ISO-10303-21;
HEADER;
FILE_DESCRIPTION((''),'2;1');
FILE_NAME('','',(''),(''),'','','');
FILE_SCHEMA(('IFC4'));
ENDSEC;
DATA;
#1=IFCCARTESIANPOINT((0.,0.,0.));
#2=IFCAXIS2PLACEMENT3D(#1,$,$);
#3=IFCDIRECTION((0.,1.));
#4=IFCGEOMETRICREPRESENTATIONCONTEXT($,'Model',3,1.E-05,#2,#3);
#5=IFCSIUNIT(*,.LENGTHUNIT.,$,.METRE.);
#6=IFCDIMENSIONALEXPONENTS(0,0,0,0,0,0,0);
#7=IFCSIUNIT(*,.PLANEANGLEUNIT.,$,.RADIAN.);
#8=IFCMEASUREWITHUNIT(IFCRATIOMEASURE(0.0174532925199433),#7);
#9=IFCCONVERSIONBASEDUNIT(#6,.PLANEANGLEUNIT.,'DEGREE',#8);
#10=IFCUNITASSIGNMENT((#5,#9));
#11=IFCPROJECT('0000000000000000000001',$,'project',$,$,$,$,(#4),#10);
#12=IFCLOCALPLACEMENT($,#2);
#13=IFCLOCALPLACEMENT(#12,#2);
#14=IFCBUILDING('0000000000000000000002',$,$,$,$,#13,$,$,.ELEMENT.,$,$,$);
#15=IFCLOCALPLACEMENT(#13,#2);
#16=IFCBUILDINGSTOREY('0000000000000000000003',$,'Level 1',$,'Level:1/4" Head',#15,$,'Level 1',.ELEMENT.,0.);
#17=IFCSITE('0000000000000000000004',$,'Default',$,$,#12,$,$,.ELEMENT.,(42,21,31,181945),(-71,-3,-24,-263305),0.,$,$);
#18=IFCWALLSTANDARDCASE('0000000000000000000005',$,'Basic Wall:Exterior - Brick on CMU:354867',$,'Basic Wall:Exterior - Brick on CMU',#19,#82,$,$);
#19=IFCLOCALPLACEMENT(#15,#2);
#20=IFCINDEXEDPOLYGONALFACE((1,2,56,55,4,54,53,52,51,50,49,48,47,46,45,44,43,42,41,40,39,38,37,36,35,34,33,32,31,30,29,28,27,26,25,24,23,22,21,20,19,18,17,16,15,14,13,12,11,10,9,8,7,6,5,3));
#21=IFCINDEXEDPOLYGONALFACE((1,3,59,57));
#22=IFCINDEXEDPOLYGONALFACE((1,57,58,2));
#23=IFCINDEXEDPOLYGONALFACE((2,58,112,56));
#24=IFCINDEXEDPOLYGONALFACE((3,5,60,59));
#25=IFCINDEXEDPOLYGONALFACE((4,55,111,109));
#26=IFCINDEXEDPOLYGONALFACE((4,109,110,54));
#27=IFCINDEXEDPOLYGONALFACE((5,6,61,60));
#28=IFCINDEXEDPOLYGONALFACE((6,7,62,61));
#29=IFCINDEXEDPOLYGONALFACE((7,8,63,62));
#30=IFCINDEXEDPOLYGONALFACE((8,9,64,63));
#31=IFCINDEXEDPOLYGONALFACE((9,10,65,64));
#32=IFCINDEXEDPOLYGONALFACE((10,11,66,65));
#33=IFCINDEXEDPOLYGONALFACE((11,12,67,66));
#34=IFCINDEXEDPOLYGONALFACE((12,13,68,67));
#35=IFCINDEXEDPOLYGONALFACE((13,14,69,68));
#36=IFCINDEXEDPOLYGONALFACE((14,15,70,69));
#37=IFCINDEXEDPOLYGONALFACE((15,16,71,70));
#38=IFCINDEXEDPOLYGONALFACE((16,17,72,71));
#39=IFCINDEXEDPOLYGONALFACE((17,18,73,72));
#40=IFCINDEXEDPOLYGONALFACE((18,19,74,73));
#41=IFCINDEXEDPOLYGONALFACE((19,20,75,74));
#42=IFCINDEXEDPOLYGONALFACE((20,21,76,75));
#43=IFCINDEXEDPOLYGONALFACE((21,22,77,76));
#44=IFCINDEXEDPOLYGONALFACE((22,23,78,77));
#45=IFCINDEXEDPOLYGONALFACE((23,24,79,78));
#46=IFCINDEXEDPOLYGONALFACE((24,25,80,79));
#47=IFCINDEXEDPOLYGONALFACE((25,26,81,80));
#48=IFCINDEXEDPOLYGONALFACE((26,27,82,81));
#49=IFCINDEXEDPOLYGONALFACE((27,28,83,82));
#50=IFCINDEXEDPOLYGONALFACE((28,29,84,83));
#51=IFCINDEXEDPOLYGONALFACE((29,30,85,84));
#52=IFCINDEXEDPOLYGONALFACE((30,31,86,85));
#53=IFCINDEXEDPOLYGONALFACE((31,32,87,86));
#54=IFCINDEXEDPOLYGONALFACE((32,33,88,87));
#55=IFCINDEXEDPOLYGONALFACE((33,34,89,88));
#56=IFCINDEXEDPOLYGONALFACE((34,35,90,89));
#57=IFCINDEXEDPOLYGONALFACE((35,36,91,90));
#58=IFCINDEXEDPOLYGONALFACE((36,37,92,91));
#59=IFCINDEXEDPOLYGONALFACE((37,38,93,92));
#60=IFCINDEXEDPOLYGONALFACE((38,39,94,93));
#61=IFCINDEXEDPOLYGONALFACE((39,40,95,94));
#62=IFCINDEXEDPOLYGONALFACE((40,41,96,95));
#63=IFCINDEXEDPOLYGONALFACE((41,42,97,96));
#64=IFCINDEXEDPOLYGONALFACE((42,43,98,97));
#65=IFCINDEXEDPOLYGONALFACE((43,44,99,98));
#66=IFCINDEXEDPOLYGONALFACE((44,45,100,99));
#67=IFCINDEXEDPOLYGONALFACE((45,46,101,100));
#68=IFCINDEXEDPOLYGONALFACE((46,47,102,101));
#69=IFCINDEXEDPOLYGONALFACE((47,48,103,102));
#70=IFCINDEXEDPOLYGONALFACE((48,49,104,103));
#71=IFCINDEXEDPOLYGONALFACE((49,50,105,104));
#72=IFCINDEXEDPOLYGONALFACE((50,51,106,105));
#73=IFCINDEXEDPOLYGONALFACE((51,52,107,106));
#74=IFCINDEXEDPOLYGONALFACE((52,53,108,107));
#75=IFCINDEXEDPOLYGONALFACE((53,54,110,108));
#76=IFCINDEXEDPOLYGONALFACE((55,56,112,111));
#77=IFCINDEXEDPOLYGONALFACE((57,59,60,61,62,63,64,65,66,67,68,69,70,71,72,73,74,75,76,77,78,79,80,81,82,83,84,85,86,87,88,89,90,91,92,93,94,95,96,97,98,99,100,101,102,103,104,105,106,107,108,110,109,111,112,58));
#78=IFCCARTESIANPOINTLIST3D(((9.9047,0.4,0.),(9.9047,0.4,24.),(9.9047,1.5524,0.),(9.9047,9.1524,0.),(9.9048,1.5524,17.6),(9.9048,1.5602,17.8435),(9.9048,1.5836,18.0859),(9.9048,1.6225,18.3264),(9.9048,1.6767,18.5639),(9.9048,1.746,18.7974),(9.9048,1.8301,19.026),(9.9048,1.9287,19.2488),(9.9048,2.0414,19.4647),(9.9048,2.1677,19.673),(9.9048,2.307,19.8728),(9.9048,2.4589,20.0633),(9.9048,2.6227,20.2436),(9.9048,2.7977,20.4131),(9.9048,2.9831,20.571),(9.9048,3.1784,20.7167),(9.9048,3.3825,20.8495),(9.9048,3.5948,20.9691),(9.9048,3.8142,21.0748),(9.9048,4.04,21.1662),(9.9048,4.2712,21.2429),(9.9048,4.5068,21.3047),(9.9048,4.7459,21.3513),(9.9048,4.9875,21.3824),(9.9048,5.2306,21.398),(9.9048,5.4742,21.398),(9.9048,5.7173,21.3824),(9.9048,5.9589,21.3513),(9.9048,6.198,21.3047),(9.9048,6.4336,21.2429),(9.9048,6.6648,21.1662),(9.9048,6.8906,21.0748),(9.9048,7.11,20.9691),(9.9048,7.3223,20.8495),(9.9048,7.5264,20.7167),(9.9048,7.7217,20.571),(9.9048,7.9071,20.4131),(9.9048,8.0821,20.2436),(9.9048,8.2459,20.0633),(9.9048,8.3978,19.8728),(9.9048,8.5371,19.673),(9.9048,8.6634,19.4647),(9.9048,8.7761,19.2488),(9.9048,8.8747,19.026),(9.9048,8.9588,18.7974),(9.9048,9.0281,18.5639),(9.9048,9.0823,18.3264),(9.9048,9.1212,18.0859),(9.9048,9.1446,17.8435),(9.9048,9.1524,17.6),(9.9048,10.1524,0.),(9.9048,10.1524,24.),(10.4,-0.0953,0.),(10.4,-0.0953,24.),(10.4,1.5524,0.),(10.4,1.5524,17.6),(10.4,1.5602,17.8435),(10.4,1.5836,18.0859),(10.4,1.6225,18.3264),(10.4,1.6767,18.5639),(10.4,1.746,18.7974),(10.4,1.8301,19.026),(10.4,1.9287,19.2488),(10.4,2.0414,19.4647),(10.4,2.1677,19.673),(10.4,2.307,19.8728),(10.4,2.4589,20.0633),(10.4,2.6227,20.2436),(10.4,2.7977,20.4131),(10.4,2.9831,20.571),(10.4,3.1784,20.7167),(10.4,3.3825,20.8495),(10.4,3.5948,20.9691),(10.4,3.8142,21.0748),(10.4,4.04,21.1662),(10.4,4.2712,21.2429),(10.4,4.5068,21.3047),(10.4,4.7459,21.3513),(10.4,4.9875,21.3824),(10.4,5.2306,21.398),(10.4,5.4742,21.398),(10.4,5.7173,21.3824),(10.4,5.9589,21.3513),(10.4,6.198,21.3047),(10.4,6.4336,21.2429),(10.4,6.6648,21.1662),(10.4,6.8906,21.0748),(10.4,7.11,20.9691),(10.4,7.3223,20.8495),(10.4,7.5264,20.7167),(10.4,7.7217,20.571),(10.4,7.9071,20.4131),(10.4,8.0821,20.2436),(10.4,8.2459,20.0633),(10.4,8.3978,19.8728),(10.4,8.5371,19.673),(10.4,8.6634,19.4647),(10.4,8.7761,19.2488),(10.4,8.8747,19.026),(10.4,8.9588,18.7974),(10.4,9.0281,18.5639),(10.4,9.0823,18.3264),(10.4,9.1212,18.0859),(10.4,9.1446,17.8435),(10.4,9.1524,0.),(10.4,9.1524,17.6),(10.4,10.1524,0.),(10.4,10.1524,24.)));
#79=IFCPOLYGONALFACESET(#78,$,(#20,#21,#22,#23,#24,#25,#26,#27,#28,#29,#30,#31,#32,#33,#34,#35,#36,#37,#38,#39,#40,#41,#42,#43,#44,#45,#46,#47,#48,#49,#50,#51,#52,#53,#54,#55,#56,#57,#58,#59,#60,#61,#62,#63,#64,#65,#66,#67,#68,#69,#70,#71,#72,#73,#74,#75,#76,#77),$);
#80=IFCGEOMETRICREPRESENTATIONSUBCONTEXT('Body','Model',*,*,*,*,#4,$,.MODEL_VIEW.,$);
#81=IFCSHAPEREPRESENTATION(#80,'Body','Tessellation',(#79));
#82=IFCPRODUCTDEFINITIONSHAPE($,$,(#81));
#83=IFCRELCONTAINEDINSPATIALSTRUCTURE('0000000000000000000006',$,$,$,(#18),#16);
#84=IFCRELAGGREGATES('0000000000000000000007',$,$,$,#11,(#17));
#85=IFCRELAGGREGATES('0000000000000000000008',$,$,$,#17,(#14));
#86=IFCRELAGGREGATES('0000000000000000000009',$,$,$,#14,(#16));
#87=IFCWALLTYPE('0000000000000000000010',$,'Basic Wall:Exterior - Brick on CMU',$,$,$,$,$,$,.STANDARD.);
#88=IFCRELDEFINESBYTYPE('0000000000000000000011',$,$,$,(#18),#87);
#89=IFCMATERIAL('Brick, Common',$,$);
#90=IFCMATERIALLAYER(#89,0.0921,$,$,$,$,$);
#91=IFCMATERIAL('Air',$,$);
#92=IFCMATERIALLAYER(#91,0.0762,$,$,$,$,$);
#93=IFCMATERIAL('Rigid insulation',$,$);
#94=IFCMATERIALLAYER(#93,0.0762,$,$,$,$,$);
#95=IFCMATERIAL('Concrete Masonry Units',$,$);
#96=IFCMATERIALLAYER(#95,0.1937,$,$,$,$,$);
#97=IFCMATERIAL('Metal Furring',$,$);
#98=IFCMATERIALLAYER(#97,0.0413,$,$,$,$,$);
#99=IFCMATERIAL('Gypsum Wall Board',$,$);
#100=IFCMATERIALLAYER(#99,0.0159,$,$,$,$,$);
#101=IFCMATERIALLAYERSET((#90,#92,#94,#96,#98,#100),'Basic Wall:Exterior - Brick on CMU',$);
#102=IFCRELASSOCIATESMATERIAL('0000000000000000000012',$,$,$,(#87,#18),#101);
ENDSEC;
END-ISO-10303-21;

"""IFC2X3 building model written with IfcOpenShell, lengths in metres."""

from ifc_helpers import new_model, entity, si_unit, converted_unit, direction, frame, frame_2d, origin, place, context, subcontext, project, spatial, polyline, circle_curve, parameter, trimmed, segment, composite_curve, outline, extrude, material, layer, layer_set, layer_usage, type_object, element, save


model = new_model("IFC2X3")

# Units and contexts
model_context = context("Model", 3, precision=1e-05, world=origin(), true_north=direction((0.0, 1.0)))
body_context = subcontext(model_context, "Body", "Model", "MODEL_VIEW")
ifc_project = project(units=[si_unit("LENGTHUNIT", "METRE"), converted_unit("PLANEANGLEUNIT", "DEGREE", entity("IfcRatioMeasure", 0.0174532925199433), si_unit("PLANEANGLEUNIT", "RADIAN"), dimensions=[0, 0, 0, 0, 0, 0, 0])], contexts=[model_context])

# Site, building, storey
site_placement = place(None, origin())
site = spatial("IfcSite", under=ifc_project, at=site_placement, Name="Default", CompositionType="ELEMENT", RefLatitude=(42, 21, 31, 181945), RefLongitude=(-71, -3, -24, -263305), RefElevation=0.0)
building_placement = place(site_placement, origin())
building = spatial("IfcBuilding", under=site, at=building_placement, CompositionType="ELEMENT")
storey_placement = place(building_placement, origin())
storey = spatial("IfcBuildingStorey", under=building, at=storey_placement, Name="Level 1", ObjectType="Level:1/4\" Head", LongName="Level 1", CompositionType="ELEMENT", Elevation=0.0)

# Wall, opening
ifc_material_1 = material(Name="Brick, Common")
ifc_layer_1 = layer(ifc_material_1, 0.0921)
ifc_material_2 = material(Name="Air")
ifc_layer_2 = layer(ifc_material_2, 0.0762)
ifc_material_3 = material(Name="Rigid insulation")
ifc_layer_3 = layer(ifc_material_3, 0.0762)
ifc_material_4 = material(Name="Concrete Masonry Units")
ifc_layer_4 = layer(ifc_material_4, 0.1937)
ifc_material_5 = material(Name="Metal Furring")
ifc_layer_5 = layer(ifc_material_5, 0.0413)
ifc_material_6 = material(Name="Gypsum Wall Board")
ifc_layer_6 = layer(ifc_material_6, 0.0159)
ifc_layer_set_1 = layer_set([ifc_layer_1, ifc_layer_2, ifc_layer_3, ifc_layer_4, ifc_layer_5, ifc_layer_6], Name="Basic Wall:Exterior - Brick on CMU")
ifc_layer_usage_1 = layer_usage(ifc_layer_set_1, "AXIS2", "POSITIVE", -0.2477)
wall_type = type_object("IfcWallType", Name="Basic Wall:Exterior - Brick on CMU", PredefinedType="STANDARD", material=ifc_layer_set_1)
wall_placement = place(storey_placement, frame((10.1524, -0.0953, 0.0), z_axis=(0.0, 0.0, 1.0), x_axis=(0.0, 1.0, 0.0)))
wall = element("IfcWallStandardCase", 1, at=wall_placement, inside=storey, type_object=wall_type, material=ifc_layer_usage_1, Name="Basic Wall:Exterior - Brick on CMU:354867", ObjectType="Basic Wall:Exterior - Brick on CMU", context=body_context, shape_type="SweptSolid", body=[
    extrude(outline(polyline([(0.0, -0.2477), (10.2477, -0.2476), (10.2477, 0.2477), (9.8301, 0.2477), (0.4953, 0.2477), (0.0, -0.2477)])), origin(), (0.0, 0.0, 1.0), 24.0),
])
opening_placement = place(wall_placement, frame((1.6461, 0.4001, 0.0)))
element("IfcOpeningElement", 2, at=opening_placement, cuts=wall, ObjectType="Opening", context=body_context, shape_type="SweptSolid", body=[
    extrude(outline(composite_curve([segment(polyline([(-8.8, -3.8), (8.8, -3.8)]), True, "CONTINUOUS"), segment(trimmed(circle_curve(frame_2d((8.8, 0.0), x_axis=(0.0, -1.0)), 3.8), [parameter(0.0)], [parameter(180.0)], True, "PARAMETER"), True, "CONTINUOUS"), segment(polyline([(8.8, 3.8), (-8.8, 3.8)]), True, "CONTINUOUS"), segment(polyline([(-8.8, 3.8), (-8.8, -3.8)]), True, "CONTINUOUS")], self_intersect=False)), frame((3.8016, -0.8001, 8.8), z_axis=(0.0, 1.0, 0.0), x_axis=(0.0, 0.0, 1.0)), (0.0, 0.0, 1.0), 0.8001),
])

save(model, "model.ifc")
